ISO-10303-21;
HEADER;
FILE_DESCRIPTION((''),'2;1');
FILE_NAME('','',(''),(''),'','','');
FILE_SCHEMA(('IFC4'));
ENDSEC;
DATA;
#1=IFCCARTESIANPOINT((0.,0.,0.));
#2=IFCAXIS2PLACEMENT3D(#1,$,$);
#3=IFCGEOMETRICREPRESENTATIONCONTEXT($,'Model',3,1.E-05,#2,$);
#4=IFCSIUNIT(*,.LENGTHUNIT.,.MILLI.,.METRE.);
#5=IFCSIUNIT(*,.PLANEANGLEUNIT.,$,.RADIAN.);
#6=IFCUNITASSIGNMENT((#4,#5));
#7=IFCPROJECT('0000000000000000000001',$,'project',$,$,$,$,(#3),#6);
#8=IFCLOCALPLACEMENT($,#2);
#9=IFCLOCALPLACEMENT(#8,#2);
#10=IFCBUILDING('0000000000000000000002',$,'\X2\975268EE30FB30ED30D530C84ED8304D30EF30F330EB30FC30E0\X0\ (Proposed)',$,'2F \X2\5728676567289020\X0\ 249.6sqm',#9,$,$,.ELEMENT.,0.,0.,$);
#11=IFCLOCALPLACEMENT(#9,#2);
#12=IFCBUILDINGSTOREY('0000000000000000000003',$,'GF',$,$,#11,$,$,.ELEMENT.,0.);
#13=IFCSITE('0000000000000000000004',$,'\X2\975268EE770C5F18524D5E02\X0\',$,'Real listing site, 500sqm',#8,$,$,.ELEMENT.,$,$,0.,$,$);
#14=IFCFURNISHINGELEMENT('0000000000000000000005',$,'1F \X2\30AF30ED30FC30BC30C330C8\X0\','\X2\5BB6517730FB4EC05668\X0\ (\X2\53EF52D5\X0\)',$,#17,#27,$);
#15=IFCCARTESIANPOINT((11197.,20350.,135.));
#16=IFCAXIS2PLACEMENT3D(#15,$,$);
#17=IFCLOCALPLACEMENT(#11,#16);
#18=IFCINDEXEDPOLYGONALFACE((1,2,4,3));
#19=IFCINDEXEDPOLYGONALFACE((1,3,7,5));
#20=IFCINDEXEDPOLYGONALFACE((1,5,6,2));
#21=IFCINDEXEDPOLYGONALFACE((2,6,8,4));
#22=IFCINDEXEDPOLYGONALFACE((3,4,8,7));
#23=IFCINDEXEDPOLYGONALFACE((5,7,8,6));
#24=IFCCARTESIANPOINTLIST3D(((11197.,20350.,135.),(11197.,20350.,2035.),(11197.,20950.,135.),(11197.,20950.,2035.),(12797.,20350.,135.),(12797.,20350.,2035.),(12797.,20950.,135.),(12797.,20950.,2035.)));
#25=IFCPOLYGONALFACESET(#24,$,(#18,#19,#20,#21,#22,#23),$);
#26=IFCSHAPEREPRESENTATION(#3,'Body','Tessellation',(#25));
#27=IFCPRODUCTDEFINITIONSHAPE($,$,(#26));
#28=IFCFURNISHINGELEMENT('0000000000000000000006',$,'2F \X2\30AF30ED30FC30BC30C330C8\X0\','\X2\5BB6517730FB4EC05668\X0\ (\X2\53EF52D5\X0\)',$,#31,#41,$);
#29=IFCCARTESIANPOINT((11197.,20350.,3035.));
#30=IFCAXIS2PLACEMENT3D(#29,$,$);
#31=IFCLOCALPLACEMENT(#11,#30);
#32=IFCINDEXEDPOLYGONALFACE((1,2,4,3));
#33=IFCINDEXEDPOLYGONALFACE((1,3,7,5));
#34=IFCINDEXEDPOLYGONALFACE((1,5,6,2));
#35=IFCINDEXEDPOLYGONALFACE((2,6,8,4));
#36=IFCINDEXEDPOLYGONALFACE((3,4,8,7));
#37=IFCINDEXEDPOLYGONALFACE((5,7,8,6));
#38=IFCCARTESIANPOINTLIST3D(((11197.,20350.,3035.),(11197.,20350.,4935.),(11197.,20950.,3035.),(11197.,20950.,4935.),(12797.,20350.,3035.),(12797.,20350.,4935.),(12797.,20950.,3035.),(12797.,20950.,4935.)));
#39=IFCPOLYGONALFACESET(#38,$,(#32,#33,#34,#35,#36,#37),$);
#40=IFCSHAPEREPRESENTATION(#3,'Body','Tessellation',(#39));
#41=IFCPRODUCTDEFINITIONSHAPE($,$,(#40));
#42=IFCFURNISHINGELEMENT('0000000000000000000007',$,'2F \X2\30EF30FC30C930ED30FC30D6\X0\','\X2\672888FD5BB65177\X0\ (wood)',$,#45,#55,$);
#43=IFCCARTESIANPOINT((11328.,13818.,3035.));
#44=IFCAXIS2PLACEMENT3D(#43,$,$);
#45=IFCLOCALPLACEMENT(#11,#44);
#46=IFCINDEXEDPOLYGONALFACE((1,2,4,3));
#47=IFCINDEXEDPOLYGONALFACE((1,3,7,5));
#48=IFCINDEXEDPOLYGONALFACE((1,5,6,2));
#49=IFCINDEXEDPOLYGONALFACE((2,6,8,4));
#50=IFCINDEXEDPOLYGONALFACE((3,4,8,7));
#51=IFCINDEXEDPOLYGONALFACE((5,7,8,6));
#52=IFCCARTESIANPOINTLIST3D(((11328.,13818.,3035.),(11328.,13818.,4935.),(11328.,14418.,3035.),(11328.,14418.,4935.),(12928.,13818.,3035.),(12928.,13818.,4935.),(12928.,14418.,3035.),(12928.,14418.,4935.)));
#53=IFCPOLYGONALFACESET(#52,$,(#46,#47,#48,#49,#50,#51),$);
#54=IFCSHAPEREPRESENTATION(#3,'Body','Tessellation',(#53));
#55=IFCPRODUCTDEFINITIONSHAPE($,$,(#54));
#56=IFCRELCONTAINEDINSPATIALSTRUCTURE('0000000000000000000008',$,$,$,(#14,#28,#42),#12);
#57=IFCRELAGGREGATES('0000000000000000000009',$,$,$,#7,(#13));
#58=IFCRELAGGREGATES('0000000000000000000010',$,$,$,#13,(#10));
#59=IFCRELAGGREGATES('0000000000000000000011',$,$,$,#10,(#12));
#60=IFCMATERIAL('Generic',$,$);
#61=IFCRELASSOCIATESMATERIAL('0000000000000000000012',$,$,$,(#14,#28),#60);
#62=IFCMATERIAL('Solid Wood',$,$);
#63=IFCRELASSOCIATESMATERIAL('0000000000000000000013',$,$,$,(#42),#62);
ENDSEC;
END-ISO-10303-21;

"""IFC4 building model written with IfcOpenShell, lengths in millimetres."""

from ifc_helpers import new_model, si_unit, frame, frame_2d, origin, place, context, project, spatial, rectangle, extrude, material, element, save


model = new_model("IFC4")

# Units and contexts
model_context = context("Model", 3, precision=1e-05, world=origin())
ifc_project = project(units=[si_unit("LENGTHUNIT", "METRE", prefix="MILLI"), si_unit("PLANEANGLEUNIT", "RADIAN")], contexts=[model_context])

# Site, building, storey
site_placement = place(None, origin())
site = spatial("IfcSite", under=ifc_project, at=site_placement, Name="青森県弘前市", ObjectType="Real listing site, 500sqm", CompositionType="ELEMENT", RefElevation=0.0)
building_placement = place(site_placement, origin())
building = spatial("IfcBuilding", under=site, at=building_placement, Name="青森・ロフト付きワンルーム (Proposed)", ObjectType="2F 在来木造 249.6sqm", CompositionType="ELEMENT", ElevationOfRefHeight=0.0, ElevationOfTerrain=0.0)
storey_placement = place(building_placement, origin())
storey = spatial("IfcBuildingStorey", under=building, at=storey_placement, Name="GF", CompositionType="ELEMENT", Elevation=0.0)

# Shared definitions
ifc_material_1 = material(Name="Solid Wood")

# Shared definitions
ifc_material_2 = material(Name="Generic")

# Furnishing elements
furnishing_1_placement = place(storey_placement, frame((11197.0, 20350.0, 135.0)))
element("IfcFurnishingElement", 1, at=furnishing_1_placement, inside=storey, material=ifc_material_2, Name="1F クローゼット", Description="家具・什器 (可動)", context=model_context, shape_type="SweptSolid", body=[
    extrude(rectangle(XDim=1600.0, YDim=600.0, at=frame_2d((800.0, 300.0))), frame((11197.0, 20350.0, 135.0)), (0.0, 0.0, 1.0), 1900.0),
])
furnishing_2_placement = place(storey_placement, frame((11197.0, 20350.0, 3035.0)))
element("IfcFurnishingElement", 2, at=furnishing_2_placement, inside=storey, material=ifc_material_2, Name="2F クローゼット", Description="家具・什器 (可動)", context=model_context, shape_type="SweptSolid", body=[
    extrude(rectangle(XDim=1600.0, YDim=600.0, at=frame_2d((800.0, 300.0))), frame((11197.0, 20350.0, 3035.0)), (0.0, 0.0, 1.0), 1900.0),
])
furnishing_3_placement = place(storey_placement, frame((11328.0, 13818.0, 3035.0)))
element("IfcFurnishingElement", 3, at=furnishing_3_placement, inside=storey, material=ifc_material_1, Name="2F ワードローブ", Description="木製家具 (wood)", context=model_context, shape_type="SweptSolid", body=[
    extrude(rectangle(XDim=1600.0, YDim=600.0, at=frame_2d((800.0, 300.0))), frame((11328.0, 13818.0, 3035.0)), (0.0, 0.0, 1.0), 1900.0),
])

save(model, "model.ifc")
